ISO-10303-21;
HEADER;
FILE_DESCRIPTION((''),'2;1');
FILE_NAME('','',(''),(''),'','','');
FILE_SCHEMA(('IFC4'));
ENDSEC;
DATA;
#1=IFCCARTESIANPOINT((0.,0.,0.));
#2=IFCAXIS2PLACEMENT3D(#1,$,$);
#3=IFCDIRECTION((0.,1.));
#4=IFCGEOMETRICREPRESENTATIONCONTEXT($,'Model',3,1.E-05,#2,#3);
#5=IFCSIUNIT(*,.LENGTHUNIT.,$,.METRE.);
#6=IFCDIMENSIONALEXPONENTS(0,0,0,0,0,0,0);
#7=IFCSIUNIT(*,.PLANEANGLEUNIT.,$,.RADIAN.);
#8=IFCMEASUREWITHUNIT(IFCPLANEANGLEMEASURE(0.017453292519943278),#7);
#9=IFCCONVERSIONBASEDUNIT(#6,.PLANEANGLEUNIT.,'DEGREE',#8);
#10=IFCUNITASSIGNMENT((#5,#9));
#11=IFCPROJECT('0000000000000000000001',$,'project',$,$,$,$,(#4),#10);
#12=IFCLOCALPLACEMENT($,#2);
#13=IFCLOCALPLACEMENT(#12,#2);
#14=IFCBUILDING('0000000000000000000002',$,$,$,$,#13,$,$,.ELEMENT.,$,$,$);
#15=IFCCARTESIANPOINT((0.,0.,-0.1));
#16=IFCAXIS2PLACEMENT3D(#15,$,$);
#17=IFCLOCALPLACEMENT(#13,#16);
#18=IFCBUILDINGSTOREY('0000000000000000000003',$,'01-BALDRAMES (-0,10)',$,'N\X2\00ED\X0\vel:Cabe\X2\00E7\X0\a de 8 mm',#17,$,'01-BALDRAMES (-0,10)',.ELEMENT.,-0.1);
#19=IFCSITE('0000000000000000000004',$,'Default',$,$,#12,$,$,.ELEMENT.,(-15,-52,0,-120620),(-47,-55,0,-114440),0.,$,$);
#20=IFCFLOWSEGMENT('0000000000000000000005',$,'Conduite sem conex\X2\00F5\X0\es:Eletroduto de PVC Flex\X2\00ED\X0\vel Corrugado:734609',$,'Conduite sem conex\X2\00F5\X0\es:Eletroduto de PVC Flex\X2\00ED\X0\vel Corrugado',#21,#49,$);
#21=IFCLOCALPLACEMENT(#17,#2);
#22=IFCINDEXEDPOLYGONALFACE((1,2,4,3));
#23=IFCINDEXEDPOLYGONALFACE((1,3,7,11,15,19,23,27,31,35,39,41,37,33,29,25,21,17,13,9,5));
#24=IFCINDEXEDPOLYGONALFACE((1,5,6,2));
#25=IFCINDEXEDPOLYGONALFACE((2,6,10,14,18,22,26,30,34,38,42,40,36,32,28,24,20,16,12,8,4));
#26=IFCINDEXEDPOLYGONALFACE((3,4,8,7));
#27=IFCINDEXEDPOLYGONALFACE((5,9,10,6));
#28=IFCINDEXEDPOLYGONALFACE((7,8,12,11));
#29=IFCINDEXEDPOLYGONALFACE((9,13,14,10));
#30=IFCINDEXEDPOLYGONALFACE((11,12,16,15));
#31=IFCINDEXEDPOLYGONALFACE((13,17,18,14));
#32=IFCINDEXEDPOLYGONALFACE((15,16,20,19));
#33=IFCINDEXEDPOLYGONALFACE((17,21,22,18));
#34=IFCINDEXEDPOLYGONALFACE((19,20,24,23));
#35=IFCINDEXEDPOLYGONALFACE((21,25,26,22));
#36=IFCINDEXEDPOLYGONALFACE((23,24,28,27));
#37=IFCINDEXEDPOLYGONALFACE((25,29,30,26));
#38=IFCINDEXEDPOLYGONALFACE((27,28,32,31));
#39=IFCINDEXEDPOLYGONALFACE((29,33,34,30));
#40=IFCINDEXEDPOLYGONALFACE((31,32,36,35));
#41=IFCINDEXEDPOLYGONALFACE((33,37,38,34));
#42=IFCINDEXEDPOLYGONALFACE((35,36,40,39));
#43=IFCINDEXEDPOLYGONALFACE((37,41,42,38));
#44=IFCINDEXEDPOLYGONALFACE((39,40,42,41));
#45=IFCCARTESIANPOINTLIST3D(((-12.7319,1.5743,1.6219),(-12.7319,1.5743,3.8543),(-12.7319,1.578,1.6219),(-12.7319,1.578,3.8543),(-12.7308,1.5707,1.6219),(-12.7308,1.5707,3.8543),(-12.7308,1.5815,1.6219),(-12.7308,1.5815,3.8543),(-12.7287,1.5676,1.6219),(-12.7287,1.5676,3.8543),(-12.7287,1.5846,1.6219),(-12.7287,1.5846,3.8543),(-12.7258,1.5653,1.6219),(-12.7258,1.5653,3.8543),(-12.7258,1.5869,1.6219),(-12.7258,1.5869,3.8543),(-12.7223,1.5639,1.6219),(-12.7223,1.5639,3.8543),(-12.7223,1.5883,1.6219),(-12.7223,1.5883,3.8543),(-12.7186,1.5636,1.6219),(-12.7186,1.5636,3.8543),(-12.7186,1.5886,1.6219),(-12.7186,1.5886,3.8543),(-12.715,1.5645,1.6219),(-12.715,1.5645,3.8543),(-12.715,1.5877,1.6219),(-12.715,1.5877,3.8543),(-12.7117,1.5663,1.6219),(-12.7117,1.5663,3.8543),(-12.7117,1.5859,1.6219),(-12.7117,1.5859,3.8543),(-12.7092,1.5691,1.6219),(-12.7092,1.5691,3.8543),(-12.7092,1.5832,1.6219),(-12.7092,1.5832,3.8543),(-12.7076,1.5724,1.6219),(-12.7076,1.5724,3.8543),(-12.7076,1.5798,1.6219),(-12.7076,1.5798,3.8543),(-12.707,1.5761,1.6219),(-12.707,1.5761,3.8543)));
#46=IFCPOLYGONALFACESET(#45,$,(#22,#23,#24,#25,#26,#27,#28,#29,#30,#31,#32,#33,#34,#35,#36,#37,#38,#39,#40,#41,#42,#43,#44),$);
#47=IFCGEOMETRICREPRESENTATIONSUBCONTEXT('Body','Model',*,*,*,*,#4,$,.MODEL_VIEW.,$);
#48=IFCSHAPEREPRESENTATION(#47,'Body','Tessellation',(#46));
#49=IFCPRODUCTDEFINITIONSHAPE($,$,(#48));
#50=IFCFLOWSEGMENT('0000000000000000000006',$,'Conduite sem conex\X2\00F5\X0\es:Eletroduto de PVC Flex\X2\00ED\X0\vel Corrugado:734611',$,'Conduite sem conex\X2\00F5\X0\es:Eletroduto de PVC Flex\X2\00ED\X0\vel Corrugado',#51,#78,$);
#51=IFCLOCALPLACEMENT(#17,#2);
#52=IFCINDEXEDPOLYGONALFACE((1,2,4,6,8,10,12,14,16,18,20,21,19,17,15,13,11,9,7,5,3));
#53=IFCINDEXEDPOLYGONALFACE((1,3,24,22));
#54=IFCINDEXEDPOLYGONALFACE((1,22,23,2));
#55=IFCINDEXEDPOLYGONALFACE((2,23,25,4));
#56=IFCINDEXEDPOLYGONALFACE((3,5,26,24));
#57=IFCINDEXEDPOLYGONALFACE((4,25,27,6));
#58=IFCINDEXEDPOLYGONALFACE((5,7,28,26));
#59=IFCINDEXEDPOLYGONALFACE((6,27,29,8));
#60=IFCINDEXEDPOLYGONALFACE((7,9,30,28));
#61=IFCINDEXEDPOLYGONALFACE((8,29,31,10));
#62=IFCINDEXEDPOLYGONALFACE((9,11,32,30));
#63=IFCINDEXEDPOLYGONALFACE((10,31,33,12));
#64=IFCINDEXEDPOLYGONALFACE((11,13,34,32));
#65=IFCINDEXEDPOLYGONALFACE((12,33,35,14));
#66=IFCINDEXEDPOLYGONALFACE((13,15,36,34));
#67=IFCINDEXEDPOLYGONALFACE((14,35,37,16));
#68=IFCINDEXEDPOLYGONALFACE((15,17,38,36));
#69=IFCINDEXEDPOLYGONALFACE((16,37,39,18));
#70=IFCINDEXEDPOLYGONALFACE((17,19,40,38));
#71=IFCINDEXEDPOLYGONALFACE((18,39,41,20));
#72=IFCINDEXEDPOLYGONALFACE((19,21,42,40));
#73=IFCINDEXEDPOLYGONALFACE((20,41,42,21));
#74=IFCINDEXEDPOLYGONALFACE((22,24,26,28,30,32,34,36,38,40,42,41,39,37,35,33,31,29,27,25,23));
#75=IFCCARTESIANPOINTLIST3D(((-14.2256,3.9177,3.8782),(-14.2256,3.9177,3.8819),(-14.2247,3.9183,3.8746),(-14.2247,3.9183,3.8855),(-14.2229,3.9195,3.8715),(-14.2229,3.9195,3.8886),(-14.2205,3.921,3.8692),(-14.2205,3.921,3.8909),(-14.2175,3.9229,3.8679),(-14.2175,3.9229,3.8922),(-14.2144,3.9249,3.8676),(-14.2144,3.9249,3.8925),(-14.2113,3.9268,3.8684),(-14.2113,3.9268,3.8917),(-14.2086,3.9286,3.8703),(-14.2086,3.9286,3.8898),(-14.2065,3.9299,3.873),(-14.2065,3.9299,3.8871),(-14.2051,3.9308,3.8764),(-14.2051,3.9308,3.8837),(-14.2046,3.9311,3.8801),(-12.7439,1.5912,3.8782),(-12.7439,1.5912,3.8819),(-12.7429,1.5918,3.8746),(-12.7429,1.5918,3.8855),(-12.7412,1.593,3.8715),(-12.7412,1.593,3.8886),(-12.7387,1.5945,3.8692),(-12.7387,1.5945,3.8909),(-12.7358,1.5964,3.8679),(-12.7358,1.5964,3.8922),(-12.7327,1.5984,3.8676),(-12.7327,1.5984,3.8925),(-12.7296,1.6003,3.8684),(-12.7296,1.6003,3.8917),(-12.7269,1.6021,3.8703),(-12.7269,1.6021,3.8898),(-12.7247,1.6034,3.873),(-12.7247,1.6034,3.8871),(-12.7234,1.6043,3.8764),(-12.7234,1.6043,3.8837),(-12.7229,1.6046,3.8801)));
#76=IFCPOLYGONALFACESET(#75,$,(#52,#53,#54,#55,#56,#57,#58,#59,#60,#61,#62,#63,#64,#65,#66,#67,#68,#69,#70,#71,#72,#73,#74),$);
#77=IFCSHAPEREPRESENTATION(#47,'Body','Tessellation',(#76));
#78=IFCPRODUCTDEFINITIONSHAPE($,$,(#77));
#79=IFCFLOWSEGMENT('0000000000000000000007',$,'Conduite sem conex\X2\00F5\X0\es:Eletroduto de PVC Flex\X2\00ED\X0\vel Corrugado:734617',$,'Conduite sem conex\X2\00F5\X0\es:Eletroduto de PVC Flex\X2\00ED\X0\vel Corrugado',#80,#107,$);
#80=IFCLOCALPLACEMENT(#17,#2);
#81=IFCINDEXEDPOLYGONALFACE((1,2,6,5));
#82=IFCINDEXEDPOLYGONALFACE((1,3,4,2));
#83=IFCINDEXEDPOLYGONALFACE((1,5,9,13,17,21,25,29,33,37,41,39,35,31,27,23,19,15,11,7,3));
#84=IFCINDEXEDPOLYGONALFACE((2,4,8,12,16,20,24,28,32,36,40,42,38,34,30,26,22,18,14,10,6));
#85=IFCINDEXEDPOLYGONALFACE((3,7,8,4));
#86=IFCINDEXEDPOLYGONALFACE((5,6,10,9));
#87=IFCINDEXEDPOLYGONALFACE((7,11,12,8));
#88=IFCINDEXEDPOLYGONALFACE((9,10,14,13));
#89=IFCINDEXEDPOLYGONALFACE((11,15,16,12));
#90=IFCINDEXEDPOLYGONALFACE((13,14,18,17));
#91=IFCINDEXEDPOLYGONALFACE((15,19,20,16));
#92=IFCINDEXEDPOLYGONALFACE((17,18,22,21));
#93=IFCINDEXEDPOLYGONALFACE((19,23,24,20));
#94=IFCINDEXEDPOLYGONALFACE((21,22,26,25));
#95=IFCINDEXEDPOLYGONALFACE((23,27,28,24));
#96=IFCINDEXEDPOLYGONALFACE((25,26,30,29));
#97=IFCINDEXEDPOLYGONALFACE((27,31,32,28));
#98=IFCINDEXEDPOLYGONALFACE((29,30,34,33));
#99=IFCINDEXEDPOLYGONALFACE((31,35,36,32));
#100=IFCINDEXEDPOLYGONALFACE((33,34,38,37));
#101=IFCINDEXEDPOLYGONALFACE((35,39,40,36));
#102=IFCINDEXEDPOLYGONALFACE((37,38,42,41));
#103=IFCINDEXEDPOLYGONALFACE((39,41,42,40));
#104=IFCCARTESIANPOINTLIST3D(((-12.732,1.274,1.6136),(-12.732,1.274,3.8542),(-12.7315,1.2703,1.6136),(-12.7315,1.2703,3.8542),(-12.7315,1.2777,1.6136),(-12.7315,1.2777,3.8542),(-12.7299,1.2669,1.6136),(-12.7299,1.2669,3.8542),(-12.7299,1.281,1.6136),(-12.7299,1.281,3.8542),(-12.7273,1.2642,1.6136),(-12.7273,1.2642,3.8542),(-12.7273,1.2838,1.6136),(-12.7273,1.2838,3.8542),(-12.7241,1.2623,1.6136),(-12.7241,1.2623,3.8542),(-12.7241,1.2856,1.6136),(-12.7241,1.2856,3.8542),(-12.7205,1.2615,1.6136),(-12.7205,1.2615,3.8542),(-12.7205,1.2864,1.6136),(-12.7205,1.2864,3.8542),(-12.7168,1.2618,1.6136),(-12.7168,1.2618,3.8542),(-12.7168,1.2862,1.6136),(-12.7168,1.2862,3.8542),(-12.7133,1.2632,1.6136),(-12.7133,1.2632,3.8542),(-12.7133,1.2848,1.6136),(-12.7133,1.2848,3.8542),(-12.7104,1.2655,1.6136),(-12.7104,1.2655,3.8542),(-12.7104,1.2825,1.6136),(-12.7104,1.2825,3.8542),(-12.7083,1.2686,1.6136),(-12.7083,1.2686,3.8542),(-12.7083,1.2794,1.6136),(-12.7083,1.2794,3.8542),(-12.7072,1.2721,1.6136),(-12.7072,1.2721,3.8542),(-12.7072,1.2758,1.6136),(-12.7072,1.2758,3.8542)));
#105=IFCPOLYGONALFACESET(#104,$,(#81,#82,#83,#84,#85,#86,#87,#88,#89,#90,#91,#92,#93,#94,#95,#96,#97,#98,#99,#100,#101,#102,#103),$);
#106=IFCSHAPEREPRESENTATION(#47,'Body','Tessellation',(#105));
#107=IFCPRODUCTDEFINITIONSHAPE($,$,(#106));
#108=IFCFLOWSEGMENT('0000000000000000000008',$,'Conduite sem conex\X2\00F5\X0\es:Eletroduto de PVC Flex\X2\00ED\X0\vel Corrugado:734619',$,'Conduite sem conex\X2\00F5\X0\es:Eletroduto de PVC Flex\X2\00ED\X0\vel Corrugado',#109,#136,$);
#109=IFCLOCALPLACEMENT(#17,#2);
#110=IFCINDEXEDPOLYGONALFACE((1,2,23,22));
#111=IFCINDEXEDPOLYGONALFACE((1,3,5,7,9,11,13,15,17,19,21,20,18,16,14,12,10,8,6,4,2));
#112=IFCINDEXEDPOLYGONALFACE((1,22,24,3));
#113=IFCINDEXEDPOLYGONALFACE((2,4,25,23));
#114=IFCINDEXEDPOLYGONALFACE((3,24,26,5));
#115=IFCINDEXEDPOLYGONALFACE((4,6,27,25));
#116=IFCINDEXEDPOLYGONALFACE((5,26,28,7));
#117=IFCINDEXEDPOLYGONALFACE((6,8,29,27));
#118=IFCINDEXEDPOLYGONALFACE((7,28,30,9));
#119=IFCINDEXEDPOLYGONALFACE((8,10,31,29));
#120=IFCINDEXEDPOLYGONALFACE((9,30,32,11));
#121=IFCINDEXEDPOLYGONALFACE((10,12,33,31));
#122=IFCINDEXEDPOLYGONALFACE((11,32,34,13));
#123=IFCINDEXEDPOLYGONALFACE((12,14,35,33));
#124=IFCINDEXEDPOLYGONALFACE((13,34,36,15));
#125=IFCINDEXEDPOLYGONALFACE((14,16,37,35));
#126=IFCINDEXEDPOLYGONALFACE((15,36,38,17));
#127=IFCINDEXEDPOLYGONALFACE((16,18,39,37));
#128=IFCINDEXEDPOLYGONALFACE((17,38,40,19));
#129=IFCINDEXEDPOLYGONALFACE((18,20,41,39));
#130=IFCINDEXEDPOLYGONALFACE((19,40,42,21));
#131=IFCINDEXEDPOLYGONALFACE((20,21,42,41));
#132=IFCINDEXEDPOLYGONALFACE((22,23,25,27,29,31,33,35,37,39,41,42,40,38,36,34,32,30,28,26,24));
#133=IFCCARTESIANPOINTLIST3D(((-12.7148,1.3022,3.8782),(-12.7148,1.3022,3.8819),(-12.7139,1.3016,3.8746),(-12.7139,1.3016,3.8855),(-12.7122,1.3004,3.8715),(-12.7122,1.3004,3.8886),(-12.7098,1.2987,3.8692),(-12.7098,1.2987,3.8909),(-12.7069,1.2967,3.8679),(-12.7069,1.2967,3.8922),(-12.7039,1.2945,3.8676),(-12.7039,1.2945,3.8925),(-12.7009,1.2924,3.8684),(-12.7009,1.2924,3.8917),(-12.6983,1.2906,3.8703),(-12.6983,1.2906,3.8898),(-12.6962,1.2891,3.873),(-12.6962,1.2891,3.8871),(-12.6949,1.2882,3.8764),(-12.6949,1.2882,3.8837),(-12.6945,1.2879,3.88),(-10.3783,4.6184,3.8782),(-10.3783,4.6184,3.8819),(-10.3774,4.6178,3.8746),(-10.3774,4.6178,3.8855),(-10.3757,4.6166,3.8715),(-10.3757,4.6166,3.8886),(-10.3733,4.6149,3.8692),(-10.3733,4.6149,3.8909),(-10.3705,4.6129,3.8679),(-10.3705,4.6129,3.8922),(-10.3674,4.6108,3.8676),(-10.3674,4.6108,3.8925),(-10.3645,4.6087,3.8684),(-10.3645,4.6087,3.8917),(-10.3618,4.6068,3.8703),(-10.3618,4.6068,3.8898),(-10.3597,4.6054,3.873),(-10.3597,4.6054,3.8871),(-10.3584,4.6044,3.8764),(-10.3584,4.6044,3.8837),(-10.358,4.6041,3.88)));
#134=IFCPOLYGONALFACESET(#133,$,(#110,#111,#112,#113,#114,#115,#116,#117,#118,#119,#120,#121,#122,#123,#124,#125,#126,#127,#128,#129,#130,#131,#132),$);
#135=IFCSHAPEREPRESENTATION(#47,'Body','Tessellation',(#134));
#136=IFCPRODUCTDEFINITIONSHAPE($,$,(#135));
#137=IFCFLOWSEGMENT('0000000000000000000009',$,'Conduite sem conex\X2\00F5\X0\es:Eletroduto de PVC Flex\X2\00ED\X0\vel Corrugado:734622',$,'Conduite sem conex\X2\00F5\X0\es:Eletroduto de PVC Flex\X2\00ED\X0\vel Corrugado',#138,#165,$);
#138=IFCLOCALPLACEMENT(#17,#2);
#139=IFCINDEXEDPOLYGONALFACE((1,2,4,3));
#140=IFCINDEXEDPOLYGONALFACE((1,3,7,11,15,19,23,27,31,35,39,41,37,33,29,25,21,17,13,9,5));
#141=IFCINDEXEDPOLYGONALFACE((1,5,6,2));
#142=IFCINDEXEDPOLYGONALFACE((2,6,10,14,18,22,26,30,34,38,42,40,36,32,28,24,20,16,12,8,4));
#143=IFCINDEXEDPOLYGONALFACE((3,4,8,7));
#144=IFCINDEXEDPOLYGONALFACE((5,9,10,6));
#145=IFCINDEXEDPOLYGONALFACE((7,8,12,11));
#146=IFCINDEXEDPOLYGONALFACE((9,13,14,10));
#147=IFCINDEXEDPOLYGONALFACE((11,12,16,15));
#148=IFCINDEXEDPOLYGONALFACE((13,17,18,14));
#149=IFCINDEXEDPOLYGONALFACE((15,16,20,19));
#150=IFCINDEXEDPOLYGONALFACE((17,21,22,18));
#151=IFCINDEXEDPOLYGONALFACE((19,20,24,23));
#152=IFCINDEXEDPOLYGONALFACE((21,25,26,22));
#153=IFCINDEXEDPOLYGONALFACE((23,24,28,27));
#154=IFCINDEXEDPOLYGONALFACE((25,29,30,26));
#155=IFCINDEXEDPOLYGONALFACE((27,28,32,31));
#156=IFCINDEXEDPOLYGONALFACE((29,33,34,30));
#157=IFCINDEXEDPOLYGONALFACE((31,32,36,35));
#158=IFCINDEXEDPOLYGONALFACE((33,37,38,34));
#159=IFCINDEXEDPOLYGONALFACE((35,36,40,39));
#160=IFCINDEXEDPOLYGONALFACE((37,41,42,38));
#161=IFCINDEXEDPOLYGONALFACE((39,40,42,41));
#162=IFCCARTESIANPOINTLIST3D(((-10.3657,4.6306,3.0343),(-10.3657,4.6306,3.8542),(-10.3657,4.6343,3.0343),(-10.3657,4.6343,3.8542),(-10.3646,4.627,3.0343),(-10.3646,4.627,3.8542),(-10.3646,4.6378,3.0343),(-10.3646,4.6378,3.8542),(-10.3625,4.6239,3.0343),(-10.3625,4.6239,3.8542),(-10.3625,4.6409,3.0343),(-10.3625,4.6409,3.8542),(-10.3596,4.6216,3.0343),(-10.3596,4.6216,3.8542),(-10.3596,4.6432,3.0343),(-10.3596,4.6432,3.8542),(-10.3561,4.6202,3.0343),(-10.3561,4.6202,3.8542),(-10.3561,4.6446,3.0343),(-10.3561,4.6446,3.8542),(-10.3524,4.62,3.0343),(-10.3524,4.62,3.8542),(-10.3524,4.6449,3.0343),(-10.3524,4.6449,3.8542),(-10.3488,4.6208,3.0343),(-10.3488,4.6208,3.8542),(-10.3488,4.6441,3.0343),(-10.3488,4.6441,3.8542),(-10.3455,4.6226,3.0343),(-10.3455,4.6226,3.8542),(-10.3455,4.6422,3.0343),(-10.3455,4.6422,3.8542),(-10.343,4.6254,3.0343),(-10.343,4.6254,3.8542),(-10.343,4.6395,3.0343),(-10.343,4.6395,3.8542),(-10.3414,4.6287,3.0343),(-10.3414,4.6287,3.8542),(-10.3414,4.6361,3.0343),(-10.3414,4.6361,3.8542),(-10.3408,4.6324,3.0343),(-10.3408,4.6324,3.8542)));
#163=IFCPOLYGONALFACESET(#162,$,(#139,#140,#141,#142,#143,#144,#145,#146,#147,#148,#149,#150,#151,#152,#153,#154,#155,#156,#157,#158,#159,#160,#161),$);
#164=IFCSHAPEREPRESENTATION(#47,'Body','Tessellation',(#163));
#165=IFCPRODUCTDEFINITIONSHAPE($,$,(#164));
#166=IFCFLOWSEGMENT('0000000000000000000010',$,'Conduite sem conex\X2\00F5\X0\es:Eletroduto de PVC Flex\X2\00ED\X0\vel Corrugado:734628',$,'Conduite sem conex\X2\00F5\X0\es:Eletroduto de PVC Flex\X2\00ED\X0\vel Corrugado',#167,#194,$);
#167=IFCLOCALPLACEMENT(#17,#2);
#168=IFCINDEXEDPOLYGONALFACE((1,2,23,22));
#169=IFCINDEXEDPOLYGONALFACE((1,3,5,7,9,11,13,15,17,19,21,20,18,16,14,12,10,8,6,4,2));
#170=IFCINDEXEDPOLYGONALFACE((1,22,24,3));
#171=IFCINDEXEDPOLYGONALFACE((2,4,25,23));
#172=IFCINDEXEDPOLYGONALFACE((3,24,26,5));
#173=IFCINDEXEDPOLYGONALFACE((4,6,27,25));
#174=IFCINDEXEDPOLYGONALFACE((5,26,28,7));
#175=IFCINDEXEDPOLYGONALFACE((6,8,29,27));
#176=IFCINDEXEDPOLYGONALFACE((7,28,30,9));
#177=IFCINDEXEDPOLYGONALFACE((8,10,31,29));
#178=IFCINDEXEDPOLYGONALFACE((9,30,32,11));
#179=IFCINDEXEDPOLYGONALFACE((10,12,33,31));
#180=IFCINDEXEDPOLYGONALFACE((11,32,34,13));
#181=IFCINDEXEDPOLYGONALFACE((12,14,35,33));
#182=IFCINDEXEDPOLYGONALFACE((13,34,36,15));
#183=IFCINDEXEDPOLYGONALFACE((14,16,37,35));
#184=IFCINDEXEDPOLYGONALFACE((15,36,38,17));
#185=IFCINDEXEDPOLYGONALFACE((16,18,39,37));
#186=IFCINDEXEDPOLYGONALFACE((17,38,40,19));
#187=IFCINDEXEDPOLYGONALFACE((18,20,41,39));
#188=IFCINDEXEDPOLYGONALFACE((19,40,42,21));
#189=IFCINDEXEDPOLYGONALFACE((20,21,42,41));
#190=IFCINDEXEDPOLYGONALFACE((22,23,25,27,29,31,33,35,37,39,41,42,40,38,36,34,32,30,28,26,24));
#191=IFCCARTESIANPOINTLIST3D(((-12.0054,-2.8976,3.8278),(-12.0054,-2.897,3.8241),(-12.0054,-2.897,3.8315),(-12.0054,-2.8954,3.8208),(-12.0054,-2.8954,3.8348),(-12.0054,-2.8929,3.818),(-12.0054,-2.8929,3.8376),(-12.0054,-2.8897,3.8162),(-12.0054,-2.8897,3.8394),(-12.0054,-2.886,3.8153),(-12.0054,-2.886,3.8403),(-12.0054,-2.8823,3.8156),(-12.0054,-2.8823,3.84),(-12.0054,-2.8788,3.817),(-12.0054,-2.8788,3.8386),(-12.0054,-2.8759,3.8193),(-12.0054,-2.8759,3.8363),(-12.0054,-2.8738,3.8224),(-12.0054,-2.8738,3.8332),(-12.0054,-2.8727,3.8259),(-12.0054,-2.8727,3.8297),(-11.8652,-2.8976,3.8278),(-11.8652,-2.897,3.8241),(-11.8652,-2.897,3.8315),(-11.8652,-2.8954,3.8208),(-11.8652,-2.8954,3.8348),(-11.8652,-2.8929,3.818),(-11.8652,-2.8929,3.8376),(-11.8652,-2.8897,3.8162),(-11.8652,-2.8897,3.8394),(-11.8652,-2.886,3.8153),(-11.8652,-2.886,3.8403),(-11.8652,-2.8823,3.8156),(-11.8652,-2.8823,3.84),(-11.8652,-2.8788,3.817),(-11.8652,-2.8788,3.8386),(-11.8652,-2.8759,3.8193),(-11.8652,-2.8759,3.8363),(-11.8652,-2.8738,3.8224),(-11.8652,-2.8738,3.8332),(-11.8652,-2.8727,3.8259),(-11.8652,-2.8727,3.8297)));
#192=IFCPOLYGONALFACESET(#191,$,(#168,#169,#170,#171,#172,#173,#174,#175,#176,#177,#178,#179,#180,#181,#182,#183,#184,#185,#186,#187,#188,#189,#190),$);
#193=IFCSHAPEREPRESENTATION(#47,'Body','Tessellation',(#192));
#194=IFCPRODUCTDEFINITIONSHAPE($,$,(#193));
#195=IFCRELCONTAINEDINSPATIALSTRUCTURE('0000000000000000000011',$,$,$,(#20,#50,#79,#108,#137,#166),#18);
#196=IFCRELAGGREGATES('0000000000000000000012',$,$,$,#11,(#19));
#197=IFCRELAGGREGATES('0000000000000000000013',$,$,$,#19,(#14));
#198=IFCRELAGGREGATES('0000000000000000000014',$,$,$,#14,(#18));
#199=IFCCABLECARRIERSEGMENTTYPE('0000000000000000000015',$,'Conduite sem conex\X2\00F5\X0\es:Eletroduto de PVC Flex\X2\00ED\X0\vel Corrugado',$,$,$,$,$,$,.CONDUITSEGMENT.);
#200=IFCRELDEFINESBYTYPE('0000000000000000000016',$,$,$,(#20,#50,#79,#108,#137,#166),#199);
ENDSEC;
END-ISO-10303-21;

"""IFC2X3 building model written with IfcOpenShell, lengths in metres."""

from ifc_helpers import new_model, entity, si_unit, converted_unit, direction, frame, frame_2d, origin, origin_2d_with_axis, place, context, subcontext, project, spatial, circle, extrude, type_object, element, save


model = new_model("IFC2X3")

# Units and contexts
model_context = context("Model", 3, precision=1e-05, world=origin(), true_north=direction((0.0, 1.0)))
body_context = subcontext(model_context, "Body", "Model", "MODEL_VIEW")
ifc_project = project(units=[si_unit("LENGTHUNIT", "METRE"), converted_unit("PLANEANGLEUNIT", "DEGREE", entity("IfcPlaneAngleMeasure", 0.017453292519943278), si_unit("PLANEANGLEUNIT", "RADIAN"), dimensions=[0, 0, 0, 0, 0, 0, 0])], contexts=[model_context])

# Site, building, storey
site_placement = place(None, origin())
site = spatial("IfcSite", under=ifc_project, at=site_placement, Name="Default", CompositionType="ELEMENT", RefLatitude=(-15, -52, 0, -120620), RefLongitude=(-47, -55, 0, -114440), RefElevation=0.0)
building_placement = place(site_placement, origin())
building = spatial("IfcBuilding", under=site, at=building_placement, CompositionType="ELEMENT")
storey_placement = place(building_placement, frame((0.0, 0.0, -0.1)))
storey = spatial("IfcBuildingStorey", under=building, at=storey_placement, Name="01-BALDRAMES (-0,10)", ObjectType="Nível:Cabeça de 8 mm", LongName="01-BALDRAMES (-0,10)", CompositionType="ELEMENT", Elevation=-0.1)

# Flow segments
cable_carrier_segment_type = type_object("IfcCableCarrierSegmentType", Name="Conduite sem conexões:Eletroduto de PVC Flexível Corrugado", PredefinedType="CONDUITSEGMENT")
flow_segment_1_placement = place(storey_placement, origin())
element("IfcFlowSegment", 1, at=flow_segment_1_placement, inside=storey, type_object=cable_carrier_segment_type, Name="Conduite sem conexões:Eletroduto de PVC Flexível Corrugado:734609", ObjectType="Conduite sem conexões:Eletroduto de PVC Flexível Corrugado", context=body_context, shape_type="SweptSolid", body=[
    extrude(circle(Radius=0.0125, at=origin_2d_with_axis()), frame((-12.7195, 1.5761, 1.6219)), (0.0, 0.0, 1.0), 2.2323),
])
flow_segment_2_placement = place(storey_placement, origin())
element("IfcFlowSegment", 2, at=flow_segment_2_placement, inside=storey, type_object=cable_carrier_segment_type, Name="Conduite sem conexões:Eletroduto de PVC Flexível Corrugado:734611", ObjectType="Conduite sem conexões:Eletroduto de PVC Flexível Corrugado", context=body_context, shape_type="SweptSolid", body=[
    extrude(circle(Radius=0.0125, at=frame_2d((0.0, 0.0), x_axis=(1.0, 0.0))), frame((-14.2152, 3.9244, 3.8801), z_axis=(0.537194, -0.843458, 0.0), x_axis=(0.843458, 0.537194, 0.0)), (0.0, 0.0, 1.0), 2.7583),
])
flow_segment_3_placement = place(storey_placement, origin())
element("IfcFlowSegment", 3, at=flow_segment_3_placement, inside=storey, type_object=cable_carrier_segment_type, Name="Conduite sem conexões:Eletroduto de PVC Flexível Corrugado:734617", ObjectType="Conduite sem conexões:Eletroduto de PVC Flexível Corrugado", context=body_context, shape_type="SweptSolid", body=[
    extrude(circle(Radius=0.0125, at=origin_2d_with_axis()), frame((-12.7195, 1.274, 1.6136), z_axis=(0.0, 0.0, 1.0), x_axis=(-1.0, 0.0, 0.0)), (0.0, 0.0, 1.0), 2.2406),
])
flow_segment_4_placement = place(storey_placement, origin())
element("IfcFlowSegment", 4, at=flow_segment_4_placement, inside=storey, type_object=cable_carrier_segment_type, Name="Conduite sem conexões:Eletroduto de PVC Flexível Corrugado:734619", ObjectType="Conduite sem conexões:Eletroduto de PVC Flexível Corrugado", context=body_context, shape_type="SweptSolid", body=[
    extrude(circle(Radius=0.0125, at=frame_2d((0.0, 0.0), x_axis=(1.0, 0.0))), frame((-12.7047, 1.2951, 3.88), z_axis=(0.575959, 0.817479, 0.0), x_axis=(0.817479, -0.575959, 0.0)), (0.0, 0.0, 1.0), 4.0567),
])
flow_segment_5_placement = place(storey_placement, origin())
element("IfcFlowSegment", 5, at=flow_segment_5_placement, inside=storey, type_object=cable_carrier_segment_type, Name="Conduite sem conexões:Eletroduto de PVC Flexível Corrugado:734622", ObjectType="Conduite sem conexões:Eletroduto de PVC Flexível Corrugado", context=body_context, shape_type="SweptSolid", body=[
    extrude(circle(Radius=0.0125, at=origin_2d_with_axis()), frame((-10.3533, 4.6324, 3.0343)), (0.0, 0.0, 1.0), 0.82),
])
flow_segment_6_placement = place(storey_placement, origin())
element("IfcFlowSegment", 6, at=flow_segment_6_placement, inside=storey, type_object=cable_carrier_segment_type, Name="Conduite sem conexões:Eletroduto de PVC Flexível Corrugado:734628", ObjectType="Conduite sem conexões:Eletroduto de PVC Flexível Corrugado", context=body_context, shape_type="SweptSolid", body=[
    extrude(circle(Radius=0.0125, at=origin_2d_with_axis()), frame((-12.0054, -2.8851, 3.8278), z_axis=(1.0, 0.0, 0.0), x_axis=(0.0, -1.0, 0.0)), (0.0, 0.0, 1.0), 0.1402),
])

save(model, "model.ifc")
